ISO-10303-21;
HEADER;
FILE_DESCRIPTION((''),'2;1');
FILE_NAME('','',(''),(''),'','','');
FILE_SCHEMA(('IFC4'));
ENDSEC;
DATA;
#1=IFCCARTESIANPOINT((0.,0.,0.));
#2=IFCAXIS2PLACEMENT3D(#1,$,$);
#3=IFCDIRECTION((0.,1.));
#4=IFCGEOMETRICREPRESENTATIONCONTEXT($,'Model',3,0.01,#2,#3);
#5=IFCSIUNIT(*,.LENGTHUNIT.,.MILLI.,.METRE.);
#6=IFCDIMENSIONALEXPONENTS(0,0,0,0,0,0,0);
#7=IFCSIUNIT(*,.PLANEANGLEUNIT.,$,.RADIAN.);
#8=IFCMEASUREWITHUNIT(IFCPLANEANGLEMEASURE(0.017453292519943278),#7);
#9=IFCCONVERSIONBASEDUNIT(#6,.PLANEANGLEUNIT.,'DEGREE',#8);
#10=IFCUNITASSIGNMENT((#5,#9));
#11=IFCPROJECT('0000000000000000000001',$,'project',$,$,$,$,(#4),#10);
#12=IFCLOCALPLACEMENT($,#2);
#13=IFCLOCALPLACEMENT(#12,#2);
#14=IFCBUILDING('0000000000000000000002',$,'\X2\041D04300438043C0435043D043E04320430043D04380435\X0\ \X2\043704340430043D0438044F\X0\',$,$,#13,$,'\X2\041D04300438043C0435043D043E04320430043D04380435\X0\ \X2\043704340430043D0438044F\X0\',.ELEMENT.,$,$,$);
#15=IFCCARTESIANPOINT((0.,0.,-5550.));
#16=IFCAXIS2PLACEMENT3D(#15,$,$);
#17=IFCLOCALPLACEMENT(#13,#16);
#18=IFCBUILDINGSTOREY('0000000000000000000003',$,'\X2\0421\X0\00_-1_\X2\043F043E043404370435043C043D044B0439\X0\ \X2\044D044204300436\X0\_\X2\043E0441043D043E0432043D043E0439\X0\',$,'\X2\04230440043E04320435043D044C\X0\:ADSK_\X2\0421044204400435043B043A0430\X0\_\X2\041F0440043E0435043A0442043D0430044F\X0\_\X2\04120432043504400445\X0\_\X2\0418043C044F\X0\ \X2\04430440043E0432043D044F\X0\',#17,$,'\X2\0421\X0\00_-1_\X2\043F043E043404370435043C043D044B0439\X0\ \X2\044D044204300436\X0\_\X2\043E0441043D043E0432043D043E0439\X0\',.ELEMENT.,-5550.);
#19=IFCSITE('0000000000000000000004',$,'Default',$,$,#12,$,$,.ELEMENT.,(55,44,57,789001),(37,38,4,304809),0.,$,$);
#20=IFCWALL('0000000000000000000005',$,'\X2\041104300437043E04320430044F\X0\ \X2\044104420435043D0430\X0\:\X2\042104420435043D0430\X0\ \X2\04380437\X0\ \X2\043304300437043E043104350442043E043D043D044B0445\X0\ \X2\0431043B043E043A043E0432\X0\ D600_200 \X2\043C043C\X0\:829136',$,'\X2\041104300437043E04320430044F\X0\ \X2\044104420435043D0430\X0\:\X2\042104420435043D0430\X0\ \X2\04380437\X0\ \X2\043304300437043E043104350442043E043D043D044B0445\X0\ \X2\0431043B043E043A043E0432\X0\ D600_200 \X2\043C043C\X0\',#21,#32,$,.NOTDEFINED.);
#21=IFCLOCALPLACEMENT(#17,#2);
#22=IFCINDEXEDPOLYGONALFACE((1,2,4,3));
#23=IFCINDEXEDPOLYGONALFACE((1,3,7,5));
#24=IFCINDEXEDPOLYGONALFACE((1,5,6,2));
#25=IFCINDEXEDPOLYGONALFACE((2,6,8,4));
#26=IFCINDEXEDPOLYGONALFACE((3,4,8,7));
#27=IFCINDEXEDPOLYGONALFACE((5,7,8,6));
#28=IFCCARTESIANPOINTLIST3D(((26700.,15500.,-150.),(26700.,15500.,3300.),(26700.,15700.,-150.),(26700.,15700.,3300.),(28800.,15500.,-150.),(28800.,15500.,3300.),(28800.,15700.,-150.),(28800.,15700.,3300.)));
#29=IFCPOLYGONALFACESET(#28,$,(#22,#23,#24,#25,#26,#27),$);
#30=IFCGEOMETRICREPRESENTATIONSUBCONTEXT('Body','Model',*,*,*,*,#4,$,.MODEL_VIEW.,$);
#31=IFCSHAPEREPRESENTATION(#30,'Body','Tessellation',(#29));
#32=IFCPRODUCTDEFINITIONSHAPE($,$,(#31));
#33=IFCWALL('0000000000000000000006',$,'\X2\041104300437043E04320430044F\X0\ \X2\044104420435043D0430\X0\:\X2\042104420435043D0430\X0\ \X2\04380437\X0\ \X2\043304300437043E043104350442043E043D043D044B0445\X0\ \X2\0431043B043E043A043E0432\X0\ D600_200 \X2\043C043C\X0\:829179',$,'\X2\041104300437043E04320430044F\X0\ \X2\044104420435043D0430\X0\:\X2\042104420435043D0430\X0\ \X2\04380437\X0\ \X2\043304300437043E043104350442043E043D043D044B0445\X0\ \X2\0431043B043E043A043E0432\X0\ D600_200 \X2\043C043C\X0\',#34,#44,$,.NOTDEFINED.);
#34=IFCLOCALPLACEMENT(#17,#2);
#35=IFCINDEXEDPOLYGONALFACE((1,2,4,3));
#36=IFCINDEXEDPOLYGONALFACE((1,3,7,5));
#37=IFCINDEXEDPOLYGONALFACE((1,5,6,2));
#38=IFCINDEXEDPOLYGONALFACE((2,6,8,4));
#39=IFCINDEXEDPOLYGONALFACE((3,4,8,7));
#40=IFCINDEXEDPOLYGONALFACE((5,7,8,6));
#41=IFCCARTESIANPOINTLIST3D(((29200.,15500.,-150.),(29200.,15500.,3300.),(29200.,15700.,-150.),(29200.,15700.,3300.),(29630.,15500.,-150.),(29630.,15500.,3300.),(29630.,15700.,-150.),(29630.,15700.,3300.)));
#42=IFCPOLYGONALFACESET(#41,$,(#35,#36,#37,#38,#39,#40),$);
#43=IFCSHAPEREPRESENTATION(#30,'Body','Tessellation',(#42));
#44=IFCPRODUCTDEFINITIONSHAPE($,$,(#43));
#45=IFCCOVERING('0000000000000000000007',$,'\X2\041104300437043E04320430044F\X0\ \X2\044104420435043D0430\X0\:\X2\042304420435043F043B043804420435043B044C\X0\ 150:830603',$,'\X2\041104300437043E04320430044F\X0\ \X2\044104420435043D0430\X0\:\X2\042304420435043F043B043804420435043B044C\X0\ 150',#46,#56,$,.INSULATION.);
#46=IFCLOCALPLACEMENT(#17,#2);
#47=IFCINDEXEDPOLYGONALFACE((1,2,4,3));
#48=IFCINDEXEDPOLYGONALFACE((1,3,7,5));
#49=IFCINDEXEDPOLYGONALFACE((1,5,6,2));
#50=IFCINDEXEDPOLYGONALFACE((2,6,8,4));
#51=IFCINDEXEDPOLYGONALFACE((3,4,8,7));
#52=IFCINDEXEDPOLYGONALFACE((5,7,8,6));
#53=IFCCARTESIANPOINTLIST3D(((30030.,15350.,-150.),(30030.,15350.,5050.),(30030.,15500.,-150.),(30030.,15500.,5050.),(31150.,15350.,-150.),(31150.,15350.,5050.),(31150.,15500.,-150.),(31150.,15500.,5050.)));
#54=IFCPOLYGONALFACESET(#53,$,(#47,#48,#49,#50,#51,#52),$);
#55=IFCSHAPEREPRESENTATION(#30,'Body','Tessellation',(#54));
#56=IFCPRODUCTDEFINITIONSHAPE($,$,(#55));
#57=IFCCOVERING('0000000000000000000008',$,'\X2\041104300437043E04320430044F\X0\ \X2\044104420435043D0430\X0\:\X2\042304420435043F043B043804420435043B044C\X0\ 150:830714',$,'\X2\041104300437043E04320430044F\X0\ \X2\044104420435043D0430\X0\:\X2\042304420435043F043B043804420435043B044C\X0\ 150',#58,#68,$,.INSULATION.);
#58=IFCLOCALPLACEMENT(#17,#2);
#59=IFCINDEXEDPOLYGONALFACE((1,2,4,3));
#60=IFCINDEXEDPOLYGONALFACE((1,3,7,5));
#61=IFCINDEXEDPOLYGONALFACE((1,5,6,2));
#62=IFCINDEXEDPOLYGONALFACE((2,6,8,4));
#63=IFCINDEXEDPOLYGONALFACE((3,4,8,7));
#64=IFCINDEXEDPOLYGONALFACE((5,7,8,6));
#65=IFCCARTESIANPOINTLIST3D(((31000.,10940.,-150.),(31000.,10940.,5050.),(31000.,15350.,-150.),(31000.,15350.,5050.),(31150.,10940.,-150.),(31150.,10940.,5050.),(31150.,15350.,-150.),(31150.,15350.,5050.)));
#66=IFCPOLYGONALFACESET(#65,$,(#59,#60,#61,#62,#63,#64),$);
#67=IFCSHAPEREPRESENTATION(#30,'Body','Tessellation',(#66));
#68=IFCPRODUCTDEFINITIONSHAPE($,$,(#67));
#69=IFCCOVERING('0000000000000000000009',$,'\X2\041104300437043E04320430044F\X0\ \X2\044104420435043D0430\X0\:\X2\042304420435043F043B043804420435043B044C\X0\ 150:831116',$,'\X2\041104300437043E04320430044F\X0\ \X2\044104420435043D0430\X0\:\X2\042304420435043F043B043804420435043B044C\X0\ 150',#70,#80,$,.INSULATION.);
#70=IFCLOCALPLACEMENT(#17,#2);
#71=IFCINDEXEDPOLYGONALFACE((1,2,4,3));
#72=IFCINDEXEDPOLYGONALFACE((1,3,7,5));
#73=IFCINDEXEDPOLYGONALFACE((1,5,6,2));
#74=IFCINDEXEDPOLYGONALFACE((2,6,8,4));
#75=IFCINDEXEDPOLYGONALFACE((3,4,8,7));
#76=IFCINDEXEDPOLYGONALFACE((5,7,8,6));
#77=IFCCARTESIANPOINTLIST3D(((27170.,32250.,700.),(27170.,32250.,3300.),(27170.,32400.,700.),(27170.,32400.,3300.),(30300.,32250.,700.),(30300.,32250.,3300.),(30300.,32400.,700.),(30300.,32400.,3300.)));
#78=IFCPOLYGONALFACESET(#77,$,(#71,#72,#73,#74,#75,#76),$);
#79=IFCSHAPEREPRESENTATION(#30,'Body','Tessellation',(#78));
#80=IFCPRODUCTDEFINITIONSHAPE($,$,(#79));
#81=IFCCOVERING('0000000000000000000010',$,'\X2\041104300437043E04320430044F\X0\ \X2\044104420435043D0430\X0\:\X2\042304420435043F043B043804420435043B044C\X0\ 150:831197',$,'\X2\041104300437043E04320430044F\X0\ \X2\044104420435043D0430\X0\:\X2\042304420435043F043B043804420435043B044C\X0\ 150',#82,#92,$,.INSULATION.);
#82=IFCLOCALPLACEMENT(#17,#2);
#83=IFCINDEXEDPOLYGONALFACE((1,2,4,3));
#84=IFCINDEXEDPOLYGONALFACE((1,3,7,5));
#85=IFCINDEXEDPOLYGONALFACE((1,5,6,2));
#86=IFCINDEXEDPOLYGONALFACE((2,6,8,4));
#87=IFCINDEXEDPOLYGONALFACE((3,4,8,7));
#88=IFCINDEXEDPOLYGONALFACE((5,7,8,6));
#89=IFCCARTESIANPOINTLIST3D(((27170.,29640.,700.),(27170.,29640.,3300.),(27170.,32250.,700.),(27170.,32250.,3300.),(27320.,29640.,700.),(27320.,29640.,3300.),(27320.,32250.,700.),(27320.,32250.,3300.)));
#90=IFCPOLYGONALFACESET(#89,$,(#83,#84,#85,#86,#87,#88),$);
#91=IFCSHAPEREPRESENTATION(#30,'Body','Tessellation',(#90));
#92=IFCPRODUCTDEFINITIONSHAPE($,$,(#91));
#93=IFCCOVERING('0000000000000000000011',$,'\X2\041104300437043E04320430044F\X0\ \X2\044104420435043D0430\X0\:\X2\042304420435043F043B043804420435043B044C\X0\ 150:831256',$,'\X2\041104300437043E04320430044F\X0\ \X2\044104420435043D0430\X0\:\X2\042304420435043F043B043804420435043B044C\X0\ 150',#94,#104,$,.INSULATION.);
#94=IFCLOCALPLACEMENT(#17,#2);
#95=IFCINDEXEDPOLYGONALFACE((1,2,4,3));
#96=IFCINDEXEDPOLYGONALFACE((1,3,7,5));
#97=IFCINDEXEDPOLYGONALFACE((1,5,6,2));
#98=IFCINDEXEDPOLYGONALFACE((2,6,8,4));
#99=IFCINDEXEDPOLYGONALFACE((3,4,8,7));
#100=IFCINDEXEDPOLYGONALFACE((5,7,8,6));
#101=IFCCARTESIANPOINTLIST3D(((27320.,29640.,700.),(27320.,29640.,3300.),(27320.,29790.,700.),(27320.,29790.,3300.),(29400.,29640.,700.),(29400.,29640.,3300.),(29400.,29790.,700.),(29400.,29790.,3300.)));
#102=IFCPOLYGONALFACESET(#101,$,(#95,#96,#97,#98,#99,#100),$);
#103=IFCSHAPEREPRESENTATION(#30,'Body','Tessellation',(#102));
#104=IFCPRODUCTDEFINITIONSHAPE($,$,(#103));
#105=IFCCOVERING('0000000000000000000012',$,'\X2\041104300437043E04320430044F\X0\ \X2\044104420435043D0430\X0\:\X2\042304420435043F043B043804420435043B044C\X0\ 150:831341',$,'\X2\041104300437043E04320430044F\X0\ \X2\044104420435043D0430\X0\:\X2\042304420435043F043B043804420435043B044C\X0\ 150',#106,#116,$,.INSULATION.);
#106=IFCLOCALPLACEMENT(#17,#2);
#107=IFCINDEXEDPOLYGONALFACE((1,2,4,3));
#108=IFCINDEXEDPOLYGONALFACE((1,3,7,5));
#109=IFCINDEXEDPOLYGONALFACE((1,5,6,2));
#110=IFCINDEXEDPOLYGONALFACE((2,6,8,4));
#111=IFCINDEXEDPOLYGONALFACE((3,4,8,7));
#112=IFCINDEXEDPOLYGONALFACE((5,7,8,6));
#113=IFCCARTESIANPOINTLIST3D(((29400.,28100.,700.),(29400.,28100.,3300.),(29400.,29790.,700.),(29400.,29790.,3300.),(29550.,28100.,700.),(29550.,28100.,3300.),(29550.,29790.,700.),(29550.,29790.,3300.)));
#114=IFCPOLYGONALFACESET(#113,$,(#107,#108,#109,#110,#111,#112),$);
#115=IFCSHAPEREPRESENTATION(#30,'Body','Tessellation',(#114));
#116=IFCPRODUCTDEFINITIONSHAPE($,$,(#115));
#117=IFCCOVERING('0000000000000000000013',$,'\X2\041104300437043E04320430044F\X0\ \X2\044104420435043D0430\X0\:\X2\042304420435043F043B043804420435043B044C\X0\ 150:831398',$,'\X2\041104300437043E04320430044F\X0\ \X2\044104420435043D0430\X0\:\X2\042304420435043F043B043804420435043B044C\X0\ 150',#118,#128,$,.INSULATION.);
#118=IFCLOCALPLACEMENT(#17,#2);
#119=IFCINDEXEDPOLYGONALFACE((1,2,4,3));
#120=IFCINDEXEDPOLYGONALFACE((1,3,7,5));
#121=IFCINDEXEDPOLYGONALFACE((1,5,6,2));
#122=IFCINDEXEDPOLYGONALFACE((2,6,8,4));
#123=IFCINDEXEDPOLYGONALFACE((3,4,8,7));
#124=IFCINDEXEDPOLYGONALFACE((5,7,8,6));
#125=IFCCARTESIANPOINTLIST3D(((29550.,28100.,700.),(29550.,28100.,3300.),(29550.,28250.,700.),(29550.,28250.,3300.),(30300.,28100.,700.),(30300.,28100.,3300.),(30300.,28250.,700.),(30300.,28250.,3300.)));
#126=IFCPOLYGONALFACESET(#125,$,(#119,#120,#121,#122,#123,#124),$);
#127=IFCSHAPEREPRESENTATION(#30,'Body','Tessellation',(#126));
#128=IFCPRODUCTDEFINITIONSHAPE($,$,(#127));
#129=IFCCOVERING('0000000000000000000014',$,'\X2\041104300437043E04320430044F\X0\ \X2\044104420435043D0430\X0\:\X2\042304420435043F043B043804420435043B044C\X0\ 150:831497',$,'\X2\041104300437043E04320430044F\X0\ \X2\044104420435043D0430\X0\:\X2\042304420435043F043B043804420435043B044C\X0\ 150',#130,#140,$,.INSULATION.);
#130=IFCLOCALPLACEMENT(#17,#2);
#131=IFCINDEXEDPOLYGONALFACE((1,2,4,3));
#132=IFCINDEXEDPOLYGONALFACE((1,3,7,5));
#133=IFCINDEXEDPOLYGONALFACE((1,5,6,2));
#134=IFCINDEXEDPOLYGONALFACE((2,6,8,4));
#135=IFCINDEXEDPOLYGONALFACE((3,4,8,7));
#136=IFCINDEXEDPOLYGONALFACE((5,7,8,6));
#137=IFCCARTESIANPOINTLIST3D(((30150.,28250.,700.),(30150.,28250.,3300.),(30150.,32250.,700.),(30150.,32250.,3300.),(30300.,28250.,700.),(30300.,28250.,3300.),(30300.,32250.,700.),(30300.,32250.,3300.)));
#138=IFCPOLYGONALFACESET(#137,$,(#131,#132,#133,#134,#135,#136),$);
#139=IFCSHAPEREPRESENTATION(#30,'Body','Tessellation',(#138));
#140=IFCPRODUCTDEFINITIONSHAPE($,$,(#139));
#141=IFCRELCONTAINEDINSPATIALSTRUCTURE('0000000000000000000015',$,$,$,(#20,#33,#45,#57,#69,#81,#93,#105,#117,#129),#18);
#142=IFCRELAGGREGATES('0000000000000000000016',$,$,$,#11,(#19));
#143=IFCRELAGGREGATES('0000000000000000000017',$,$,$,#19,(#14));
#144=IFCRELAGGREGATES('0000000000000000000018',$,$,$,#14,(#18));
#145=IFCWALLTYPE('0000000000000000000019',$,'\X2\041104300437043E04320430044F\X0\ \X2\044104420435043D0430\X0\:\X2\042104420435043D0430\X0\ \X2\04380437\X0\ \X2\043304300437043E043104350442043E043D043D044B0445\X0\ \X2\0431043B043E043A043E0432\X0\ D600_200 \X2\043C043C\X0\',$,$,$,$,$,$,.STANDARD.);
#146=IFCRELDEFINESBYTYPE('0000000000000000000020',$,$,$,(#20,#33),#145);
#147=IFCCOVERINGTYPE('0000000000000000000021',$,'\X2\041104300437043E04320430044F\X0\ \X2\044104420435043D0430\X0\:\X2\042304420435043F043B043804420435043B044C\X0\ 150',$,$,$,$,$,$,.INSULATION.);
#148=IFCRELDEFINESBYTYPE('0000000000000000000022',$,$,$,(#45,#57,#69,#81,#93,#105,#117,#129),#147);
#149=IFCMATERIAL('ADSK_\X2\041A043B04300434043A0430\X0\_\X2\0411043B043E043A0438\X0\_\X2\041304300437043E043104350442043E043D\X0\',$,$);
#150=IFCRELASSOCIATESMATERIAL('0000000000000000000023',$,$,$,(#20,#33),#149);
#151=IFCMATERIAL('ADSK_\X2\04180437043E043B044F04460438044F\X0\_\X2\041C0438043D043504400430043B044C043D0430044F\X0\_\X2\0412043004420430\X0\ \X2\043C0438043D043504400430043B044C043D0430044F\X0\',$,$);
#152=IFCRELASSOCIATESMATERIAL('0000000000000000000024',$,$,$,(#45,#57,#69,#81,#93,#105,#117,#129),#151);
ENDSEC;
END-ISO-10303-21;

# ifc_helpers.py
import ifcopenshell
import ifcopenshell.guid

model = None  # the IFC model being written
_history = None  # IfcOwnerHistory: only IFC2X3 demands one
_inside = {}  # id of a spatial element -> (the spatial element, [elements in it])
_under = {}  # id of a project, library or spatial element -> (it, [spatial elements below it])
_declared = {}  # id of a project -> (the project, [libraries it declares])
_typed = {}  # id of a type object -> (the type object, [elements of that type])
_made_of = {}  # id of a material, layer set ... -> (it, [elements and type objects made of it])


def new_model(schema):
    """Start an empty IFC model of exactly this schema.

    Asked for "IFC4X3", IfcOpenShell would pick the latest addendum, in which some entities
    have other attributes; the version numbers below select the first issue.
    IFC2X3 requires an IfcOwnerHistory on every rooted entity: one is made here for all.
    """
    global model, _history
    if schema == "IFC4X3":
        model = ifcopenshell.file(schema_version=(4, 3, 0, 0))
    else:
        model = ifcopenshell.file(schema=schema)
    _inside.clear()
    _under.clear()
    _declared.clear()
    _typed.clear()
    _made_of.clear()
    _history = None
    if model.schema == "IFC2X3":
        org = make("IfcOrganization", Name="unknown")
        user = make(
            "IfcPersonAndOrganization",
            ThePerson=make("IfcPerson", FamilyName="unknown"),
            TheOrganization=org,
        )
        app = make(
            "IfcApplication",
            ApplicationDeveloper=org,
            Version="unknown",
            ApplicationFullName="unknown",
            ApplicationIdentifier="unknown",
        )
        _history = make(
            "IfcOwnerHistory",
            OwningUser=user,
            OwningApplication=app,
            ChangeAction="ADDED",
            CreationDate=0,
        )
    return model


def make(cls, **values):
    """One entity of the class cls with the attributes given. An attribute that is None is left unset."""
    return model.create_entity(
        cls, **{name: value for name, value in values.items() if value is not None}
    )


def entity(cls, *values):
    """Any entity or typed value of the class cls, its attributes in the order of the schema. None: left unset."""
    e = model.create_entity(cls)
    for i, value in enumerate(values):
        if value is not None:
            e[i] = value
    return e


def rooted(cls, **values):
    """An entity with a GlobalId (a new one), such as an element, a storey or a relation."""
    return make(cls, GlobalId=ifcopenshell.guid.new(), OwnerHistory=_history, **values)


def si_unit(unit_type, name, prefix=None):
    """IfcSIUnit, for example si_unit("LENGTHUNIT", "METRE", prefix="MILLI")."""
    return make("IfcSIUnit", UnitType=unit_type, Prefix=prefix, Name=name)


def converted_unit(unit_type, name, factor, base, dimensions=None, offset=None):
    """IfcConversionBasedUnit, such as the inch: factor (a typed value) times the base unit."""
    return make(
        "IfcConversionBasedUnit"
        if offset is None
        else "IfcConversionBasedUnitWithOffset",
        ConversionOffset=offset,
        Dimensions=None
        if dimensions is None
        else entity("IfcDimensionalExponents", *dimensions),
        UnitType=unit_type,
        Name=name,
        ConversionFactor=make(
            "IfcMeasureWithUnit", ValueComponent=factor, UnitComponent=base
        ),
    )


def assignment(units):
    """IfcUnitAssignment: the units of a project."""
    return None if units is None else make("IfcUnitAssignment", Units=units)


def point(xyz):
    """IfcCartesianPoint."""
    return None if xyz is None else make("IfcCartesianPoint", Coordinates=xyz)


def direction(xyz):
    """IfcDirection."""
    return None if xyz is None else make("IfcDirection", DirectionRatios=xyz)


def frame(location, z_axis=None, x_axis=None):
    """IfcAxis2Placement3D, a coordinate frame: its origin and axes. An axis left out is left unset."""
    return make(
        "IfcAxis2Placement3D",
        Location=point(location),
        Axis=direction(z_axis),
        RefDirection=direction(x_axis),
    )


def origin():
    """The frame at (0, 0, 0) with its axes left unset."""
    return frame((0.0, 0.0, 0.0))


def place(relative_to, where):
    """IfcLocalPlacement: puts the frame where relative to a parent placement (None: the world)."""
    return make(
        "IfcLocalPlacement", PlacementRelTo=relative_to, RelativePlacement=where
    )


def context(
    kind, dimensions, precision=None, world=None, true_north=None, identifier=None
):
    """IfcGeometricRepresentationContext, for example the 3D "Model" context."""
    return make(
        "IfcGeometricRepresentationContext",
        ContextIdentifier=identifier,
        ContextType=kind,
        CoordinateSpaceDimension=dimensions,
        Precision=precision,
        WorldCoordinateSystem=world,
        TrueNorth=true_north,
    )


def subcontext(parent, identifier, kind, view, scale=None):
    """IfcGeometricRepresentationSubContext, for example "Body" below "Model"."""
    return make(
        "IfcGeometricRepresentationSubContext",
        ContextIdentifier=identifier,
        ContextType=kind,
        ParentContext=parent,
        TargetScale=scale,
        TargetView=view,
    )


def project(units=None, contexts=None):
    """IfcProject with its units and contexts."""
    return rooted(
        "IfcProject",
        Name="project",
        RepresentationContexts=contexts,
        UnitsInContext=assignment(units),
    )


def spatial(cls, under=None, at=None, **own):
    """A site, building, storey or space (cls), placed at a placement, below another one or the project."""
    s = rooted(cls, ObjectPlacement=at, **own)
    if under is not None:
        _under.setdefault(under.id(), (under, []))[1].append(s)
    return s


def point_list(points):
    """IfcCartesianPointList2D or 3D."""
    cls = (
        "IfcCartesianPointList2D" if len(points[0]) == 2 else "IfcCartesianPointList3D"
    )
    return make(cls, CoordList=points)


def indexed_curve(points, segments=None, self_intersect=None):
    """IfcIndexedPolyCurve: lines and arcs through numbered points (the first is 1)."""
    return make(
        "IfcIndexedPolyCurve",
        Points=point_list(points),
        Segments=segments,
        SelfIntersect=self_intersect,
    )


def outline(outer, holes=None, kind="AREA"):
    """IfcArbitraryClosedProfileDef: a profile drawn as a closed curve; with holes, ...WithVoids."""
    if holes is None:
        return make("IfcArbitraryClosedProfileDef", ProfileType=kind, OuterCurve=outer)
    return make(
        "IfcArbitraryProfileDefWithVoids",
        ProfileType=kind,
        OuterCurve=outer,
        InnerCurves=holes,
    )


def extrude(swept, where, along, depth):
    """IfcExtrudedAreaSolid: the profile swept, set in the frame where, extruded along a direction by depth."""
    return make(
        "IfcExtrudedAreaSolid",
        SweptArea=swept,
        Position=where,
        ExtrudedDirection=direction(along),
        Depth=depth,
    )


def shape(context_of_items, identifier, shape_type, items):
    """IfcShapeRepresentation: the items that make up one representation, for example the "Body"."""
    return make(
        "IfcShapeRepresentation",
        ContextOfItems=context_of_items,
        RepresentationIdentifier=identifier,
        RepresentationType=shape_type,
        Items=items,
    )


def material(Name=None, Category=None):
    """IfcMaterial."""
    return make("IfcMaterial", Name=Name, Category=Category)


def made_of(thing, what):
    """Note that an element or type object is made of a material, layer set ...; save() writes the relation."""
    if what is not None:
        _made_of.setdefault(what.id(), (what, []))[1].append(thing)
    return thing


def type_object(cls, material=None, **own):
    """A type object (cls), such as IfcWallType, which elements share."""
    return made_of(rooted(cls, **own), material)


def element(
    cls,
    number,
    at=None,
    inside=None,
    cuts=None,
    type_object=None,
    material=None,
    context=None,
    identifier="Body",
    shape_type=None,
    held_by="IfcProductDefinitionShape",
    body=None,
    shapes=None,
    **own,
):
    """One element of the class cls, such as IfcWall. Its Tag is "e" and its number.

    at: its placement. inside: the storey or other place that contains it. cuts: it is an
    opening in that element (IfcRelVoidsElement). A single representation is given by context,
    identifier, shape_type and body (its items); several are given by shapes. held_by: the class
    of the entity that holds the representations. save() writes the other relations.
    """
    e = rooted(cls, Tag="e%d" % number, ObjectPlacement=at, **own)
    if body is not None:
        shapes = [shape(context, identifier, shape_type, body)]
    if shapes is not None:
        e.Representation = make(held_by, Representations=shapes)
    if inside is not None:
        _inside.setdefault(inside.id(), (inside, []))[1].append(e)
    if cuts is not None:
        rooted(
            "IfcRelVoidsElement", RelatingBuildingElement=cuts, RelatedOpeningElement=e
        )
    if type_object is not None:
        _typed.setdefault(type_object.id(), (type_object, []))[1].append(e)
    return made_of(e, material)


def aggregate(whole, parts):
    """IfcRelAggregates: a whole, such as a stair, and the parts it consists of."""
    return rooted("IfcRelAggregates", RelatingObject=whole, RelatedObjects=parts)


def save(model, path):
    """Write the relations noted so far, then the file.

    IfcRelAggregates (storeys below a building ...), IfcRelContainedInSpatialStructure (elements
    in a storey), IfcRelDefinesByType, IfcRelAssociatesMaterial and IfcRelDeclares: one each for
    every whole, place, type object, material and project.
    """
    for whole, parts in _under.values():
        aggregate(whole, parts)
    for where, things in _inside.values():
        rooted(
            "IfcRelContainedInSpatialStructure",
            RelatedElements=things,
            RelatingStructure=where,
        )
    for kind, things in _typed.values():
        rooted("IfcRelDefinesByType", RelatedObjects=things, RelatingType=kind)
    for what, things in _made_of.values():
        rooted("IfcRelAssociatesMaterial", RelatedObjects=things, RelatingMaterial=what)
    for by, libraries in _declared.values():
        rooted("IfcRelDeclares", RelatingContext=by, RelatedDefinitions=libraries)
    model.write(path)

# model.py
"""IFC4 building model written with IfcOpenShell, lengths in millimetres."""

from ifc_helpers import new_model, entity, si_unit, converted_unit, direction, frame, origin, place, context, subcontext, project, spatial, indexed_curve, outline, extrude, material, type_object, element, save


model = new_model("IFC4")

# Units and contexts
model_context = context("Model", 3, precision=0.01, world=origin(), true_north=direction((0.0, 1.0)))
body_context = subcontext(model_context, "Body", "Model", "MODEL_VIEW")
ifc_project = project(units=[si_unit("LENGTHUNIT", "METRE", prefix="MILLI"), converted_unit("PLANEANGLEUNIT", "DEGREE", entity("IfcPlaneAngleMeasure", 0.017453292519943278), si_unit("PLANEANGLEUNIT", "RADIAN"), dimensions=[0, 0, 0, 0, 0, 0, 0])], contexts=[model_context])

# Site, building, storey
site_placement = place(None, origin())
site = spatial("IfcSite", under=ifc_project, at=site_placement, Name="Default", CompositionType="ELEMENT", RefLatitude=(55, 44, 57, 789001), RefLongitude=(37, 38, 4, 304809), RefElevation=0.0)
building_placement = place(site_placement, origin())
building = spatial("IfcBuilding", under=site, at=building_placement, Name="Наименование здания", LongName="Наименование здания", CompositionType="ELEMENT")
storey_placement = place(building_placement, frame((0.0, 0.0, -5550.0)))
storey = spatial("IfcBuildingStorey", under=building, at=storey_placement, Name="С00_-1_подземный этаж_основной", ObjectType="Уровень:ADSK_Стрелка_Проектная_Вверх_Имя уровня", LongName="С00_-1_подземный этаж_основной", CompositionType="ELEMENT", Elevation=-5550.0)

# Walls
ifc_material_1 = material(Name="ADSK_Кладка_Блоки_Газобетон")
wall_type_1 = type_object("IfcWallType", Name="Базовая стена:Стена из газобетонных блоков D600_200 мм", PredefinedType="STANDARD")
wall_1_placement = place(storey_placement, frame((26700.0, 15600.0, -150.0)))
element("IfcWall", 1, at=wall_1_placement, inside=storey, type_object=wall_type_1, material=ifc_material_1, Name="Базовая стена:Стена из газобетонных блоков D600_200 мм:829136", ObjectType="Базовая стена:Стена из газобетонных блоков D600_200 мм", PredefinedType="NOTDEFINED", context=body_context, shape_type="SweptSolid", body=[
    extrude(outline(indexed_curve([(2100.0, 100.0), (0.0, 100.0), (0.0, -100.0), (2100.0, -100.0), (2100.0, 100.0)], self_intersect=False)), origin(), (0.0, 0.0, 1.0), 3450.0),
])
wall_2_placement = place(storey_placement, frame((29200.0, 15600.0, -150.0)))
element("IfcWall", 2, at=wall_2_placement, inside=storey, type_object=wall_type_1, material=ifc_material_1, Name="Базовая стена:Стена из газобетонных блоков D600_200 мм:829179", ObjectType="Базовая стена:Стена из газобетонных блоков D600_200 мм", PredefinedType="NOTDEFINED", context=body_context, shape_type="SweptSolid", body=[
    extrude(outline(indexed_curve([(430.0, 100.0), (0.0, 100.0), (0.0, -100.0), (430.0, -100.0), (430.0, 100.0)], self_intersect=False)), origin(), (0.0, 0.0, 1.0), 3450.0),
])

# Coverings
ifc_material_2 = material(Name="ADSK_Изоляция_Минеральная_Вата минеральная")
covering_type = type_object("IfcCoveringType", Name="Базовая стена:Утеплитель 150", PredefinedType="INSULATION")
covering_1_placement = place(storey_placement, frame((30030.0, 15425.0, -150.0)))
element("IfcCovering", 3, at=covering_1_placement, inside=storey, type_object=covering_type, material=ifc_material_2, Name="Базовая стена:Утеплитель 150:830603", ObjectType="Базовая стена:Утеплитель 150", PredefinedType="INSULATION", context=body_context, shape_type="SweptSolid", body=[
    extrude(outline(indexed_curve([(1120.0, 75.0), (0.0, 75.0), (0.0, -75.0), (1120.0, -75.0), (1120.0, 75.0)], self_intersect=False)), origin(), (0.0, 0.0, 1.0), 5200.0),
])
covering_2_placement = place(storey_placement, frame((31075.0, 15350.0, -150.0), z_axis=(0.0, 0.0, 1.0), x_axis=(0.0, -1.0, 0.0)))
element("IfcCovering", 4, at=covering_2_placement, inside=storey, type_object=covering_type, material=ifc_material_2, Name="Базовая стена:Утеплитель 150:830714", ObjectType="Базовая стена:Утеплитель 150", PredefinedType="INSULATION", context=body_context, shape_type="SweptSolid", body=[
    extrude(outline(indexed_curve([(4410.0, 75.0), (0.0, 75.0), (0.0, -75.0), (4410.0, -75.0), (4410.0, 75.0)], self_intersect=False)), origin(), (0.0, 0.0, 1.0), 5200.0),
])
covering_3_placement = place(storey_placement, frame((30300.0, 32325.0, 700.0), z_axis=(0.0, 0.0, 1.0), x_axis=(-1.0, 0.0, 0.0)))
element("IfcCovering", 5, at=covering_3_placement, inside=storey, type_object=covering_type, material=ifc_material_2, Name="Базовая стена:Утеплитель 150:831116", ObjectType="Базовая стена:Утеплитель 150", PredefinedType="INSULATION", context=body_context, shape_type="SweptSolid", body=[
    extrude(outline(indexed_curve([(3130.0, 75.0), (0.0, 75.0), (0.0, -75.0), (3130.0, -75.0), (3130.0, 75.0)], self_intersect=False)), origin(), (0.0, 0.0, 1.0), 2600.0),
])
covering_4_placement = place(storey_placement, frame((27245.0, 32250.0, 700.0), z_axis=(0.0, 0.0, 1.0), x_axis=(0.0, -1.0, 0.0)))
element("IfcCovering", 6, at=covering_4_placement, inside=storey, type_object=covering_type, material=ifc_material_2, Name="Базовая стена:Утеплитель 150:831197", ObjectType="Базовая стена:Утеплитель 150", PredefinedType="INSULATION", context=body_context, shape_type="SweptSolid", body=[
    extrude(outline(indexed_curve([(2610.0, 75.0), (0.0, 75.0), (0.0, -75.0), (2610.0, -75.0), (2610.0, 75.0)], self_intersect=False)), origin(), (0.0, 0.0, 1.0), 2600.0),
])
covering_5_placement = place(storey_placement, frame((27320.0, 29715.0, 700.0)))
element("IfcCovering", 7, at=covering_5_placement, inside=storey, type_object=covering_type, material=ifc_material_2, Name="Базовая стена:Утеплитель 150:831256", ObjectType="Базовая стена:Утеплитель 150", PredefinedType="INSULATION", context=body_context, shape_type="SweptSolid", body=[
    extrude(outline(indexed_curve([(2080.0, 75.0), (0.0, 75.0), (0.0, -75.0), (2080.0, -75.0), (2080.0, 75.0)], self_intersect=False)), origin(), (0.0, 0.0, 1.0), 2600.0),
])
covering_6_placement = place(storey_placement, frame((29475.0, 29790.0, 700.0), z_axis=(0.0, 0.0, 1.0), x_axis=(0.0, -1.0, 0.0)))
element("IfcCovering", 8, at=covering_6_placement, inside=storey, type_object=covering_type, material=ifc_material_2, Name="Базовая стена:Утеплитель 150:831341", ObjectType="Базовая стена:Утеплитель 150", PredefinedType="INSULATION", context=body_context, shape_type="SweptSolid", body=[
    extrude(outline(indexed_curve([(1690.0, 75.0), (0.0, 75.0), (0.0, -75.0), (1690.0, -75.0), (1690.0, 75.0)], self_intersect=False)), origin(), (0.0, 0.0, 1.0), 2600.0),
])
covering_7_placement = place(storey_placement, frame((29550.0, 28175.0, 700.0)))
element("IfcCovering", 9, at=covering_7_placement, inside=storey, type_object=covering_type, material=ifc_material_2, Name="Базовая стена:Утеплитель 150:831398", ObjectType="Базовая стена:Утеплитель 150", PredefinedType="INSULATION", context=body_context, shape_type="SweptSolid", body=[
    extrude(outline(indexed_curve([(750.0, 75.0), (0.0, 75.0), (0.0, -75.0), (750.0, -75.0), (750.0, 75.0)], self_intersect=False)), origin(), (0.0, 0.0, 1.0), 2600.0),
])
covering_8_placement = place(storey_placement, frame((30225.0, 28250.0, 700.0), z_axis=(0.0, 0.0, 1.0), x_axis=(0.0, 1.0, 0.0)))
element("IfcCovering", 10, at=covering_8_placement, inside=storey, type_object=covering_type, material=ifc_material_2, Name="Базовая стена:Утеплитель 150:831497", ObjectType="Базовая стена:Утеплитель 150", PredefinedType="INSULATION", context=body_context, shape_type="SweptSolid", body=[
    extrude(outline(indexed_curve([(4000.0, 75.0), (0.0, 75.0), (0.0, -75.0), (4000.0, -75.0), (4000.0, 75.0)], self_intersect=False)), origin(), (0.0, 0.0, 1.0), 2600.0),
])

save(model, "model.ifc")
